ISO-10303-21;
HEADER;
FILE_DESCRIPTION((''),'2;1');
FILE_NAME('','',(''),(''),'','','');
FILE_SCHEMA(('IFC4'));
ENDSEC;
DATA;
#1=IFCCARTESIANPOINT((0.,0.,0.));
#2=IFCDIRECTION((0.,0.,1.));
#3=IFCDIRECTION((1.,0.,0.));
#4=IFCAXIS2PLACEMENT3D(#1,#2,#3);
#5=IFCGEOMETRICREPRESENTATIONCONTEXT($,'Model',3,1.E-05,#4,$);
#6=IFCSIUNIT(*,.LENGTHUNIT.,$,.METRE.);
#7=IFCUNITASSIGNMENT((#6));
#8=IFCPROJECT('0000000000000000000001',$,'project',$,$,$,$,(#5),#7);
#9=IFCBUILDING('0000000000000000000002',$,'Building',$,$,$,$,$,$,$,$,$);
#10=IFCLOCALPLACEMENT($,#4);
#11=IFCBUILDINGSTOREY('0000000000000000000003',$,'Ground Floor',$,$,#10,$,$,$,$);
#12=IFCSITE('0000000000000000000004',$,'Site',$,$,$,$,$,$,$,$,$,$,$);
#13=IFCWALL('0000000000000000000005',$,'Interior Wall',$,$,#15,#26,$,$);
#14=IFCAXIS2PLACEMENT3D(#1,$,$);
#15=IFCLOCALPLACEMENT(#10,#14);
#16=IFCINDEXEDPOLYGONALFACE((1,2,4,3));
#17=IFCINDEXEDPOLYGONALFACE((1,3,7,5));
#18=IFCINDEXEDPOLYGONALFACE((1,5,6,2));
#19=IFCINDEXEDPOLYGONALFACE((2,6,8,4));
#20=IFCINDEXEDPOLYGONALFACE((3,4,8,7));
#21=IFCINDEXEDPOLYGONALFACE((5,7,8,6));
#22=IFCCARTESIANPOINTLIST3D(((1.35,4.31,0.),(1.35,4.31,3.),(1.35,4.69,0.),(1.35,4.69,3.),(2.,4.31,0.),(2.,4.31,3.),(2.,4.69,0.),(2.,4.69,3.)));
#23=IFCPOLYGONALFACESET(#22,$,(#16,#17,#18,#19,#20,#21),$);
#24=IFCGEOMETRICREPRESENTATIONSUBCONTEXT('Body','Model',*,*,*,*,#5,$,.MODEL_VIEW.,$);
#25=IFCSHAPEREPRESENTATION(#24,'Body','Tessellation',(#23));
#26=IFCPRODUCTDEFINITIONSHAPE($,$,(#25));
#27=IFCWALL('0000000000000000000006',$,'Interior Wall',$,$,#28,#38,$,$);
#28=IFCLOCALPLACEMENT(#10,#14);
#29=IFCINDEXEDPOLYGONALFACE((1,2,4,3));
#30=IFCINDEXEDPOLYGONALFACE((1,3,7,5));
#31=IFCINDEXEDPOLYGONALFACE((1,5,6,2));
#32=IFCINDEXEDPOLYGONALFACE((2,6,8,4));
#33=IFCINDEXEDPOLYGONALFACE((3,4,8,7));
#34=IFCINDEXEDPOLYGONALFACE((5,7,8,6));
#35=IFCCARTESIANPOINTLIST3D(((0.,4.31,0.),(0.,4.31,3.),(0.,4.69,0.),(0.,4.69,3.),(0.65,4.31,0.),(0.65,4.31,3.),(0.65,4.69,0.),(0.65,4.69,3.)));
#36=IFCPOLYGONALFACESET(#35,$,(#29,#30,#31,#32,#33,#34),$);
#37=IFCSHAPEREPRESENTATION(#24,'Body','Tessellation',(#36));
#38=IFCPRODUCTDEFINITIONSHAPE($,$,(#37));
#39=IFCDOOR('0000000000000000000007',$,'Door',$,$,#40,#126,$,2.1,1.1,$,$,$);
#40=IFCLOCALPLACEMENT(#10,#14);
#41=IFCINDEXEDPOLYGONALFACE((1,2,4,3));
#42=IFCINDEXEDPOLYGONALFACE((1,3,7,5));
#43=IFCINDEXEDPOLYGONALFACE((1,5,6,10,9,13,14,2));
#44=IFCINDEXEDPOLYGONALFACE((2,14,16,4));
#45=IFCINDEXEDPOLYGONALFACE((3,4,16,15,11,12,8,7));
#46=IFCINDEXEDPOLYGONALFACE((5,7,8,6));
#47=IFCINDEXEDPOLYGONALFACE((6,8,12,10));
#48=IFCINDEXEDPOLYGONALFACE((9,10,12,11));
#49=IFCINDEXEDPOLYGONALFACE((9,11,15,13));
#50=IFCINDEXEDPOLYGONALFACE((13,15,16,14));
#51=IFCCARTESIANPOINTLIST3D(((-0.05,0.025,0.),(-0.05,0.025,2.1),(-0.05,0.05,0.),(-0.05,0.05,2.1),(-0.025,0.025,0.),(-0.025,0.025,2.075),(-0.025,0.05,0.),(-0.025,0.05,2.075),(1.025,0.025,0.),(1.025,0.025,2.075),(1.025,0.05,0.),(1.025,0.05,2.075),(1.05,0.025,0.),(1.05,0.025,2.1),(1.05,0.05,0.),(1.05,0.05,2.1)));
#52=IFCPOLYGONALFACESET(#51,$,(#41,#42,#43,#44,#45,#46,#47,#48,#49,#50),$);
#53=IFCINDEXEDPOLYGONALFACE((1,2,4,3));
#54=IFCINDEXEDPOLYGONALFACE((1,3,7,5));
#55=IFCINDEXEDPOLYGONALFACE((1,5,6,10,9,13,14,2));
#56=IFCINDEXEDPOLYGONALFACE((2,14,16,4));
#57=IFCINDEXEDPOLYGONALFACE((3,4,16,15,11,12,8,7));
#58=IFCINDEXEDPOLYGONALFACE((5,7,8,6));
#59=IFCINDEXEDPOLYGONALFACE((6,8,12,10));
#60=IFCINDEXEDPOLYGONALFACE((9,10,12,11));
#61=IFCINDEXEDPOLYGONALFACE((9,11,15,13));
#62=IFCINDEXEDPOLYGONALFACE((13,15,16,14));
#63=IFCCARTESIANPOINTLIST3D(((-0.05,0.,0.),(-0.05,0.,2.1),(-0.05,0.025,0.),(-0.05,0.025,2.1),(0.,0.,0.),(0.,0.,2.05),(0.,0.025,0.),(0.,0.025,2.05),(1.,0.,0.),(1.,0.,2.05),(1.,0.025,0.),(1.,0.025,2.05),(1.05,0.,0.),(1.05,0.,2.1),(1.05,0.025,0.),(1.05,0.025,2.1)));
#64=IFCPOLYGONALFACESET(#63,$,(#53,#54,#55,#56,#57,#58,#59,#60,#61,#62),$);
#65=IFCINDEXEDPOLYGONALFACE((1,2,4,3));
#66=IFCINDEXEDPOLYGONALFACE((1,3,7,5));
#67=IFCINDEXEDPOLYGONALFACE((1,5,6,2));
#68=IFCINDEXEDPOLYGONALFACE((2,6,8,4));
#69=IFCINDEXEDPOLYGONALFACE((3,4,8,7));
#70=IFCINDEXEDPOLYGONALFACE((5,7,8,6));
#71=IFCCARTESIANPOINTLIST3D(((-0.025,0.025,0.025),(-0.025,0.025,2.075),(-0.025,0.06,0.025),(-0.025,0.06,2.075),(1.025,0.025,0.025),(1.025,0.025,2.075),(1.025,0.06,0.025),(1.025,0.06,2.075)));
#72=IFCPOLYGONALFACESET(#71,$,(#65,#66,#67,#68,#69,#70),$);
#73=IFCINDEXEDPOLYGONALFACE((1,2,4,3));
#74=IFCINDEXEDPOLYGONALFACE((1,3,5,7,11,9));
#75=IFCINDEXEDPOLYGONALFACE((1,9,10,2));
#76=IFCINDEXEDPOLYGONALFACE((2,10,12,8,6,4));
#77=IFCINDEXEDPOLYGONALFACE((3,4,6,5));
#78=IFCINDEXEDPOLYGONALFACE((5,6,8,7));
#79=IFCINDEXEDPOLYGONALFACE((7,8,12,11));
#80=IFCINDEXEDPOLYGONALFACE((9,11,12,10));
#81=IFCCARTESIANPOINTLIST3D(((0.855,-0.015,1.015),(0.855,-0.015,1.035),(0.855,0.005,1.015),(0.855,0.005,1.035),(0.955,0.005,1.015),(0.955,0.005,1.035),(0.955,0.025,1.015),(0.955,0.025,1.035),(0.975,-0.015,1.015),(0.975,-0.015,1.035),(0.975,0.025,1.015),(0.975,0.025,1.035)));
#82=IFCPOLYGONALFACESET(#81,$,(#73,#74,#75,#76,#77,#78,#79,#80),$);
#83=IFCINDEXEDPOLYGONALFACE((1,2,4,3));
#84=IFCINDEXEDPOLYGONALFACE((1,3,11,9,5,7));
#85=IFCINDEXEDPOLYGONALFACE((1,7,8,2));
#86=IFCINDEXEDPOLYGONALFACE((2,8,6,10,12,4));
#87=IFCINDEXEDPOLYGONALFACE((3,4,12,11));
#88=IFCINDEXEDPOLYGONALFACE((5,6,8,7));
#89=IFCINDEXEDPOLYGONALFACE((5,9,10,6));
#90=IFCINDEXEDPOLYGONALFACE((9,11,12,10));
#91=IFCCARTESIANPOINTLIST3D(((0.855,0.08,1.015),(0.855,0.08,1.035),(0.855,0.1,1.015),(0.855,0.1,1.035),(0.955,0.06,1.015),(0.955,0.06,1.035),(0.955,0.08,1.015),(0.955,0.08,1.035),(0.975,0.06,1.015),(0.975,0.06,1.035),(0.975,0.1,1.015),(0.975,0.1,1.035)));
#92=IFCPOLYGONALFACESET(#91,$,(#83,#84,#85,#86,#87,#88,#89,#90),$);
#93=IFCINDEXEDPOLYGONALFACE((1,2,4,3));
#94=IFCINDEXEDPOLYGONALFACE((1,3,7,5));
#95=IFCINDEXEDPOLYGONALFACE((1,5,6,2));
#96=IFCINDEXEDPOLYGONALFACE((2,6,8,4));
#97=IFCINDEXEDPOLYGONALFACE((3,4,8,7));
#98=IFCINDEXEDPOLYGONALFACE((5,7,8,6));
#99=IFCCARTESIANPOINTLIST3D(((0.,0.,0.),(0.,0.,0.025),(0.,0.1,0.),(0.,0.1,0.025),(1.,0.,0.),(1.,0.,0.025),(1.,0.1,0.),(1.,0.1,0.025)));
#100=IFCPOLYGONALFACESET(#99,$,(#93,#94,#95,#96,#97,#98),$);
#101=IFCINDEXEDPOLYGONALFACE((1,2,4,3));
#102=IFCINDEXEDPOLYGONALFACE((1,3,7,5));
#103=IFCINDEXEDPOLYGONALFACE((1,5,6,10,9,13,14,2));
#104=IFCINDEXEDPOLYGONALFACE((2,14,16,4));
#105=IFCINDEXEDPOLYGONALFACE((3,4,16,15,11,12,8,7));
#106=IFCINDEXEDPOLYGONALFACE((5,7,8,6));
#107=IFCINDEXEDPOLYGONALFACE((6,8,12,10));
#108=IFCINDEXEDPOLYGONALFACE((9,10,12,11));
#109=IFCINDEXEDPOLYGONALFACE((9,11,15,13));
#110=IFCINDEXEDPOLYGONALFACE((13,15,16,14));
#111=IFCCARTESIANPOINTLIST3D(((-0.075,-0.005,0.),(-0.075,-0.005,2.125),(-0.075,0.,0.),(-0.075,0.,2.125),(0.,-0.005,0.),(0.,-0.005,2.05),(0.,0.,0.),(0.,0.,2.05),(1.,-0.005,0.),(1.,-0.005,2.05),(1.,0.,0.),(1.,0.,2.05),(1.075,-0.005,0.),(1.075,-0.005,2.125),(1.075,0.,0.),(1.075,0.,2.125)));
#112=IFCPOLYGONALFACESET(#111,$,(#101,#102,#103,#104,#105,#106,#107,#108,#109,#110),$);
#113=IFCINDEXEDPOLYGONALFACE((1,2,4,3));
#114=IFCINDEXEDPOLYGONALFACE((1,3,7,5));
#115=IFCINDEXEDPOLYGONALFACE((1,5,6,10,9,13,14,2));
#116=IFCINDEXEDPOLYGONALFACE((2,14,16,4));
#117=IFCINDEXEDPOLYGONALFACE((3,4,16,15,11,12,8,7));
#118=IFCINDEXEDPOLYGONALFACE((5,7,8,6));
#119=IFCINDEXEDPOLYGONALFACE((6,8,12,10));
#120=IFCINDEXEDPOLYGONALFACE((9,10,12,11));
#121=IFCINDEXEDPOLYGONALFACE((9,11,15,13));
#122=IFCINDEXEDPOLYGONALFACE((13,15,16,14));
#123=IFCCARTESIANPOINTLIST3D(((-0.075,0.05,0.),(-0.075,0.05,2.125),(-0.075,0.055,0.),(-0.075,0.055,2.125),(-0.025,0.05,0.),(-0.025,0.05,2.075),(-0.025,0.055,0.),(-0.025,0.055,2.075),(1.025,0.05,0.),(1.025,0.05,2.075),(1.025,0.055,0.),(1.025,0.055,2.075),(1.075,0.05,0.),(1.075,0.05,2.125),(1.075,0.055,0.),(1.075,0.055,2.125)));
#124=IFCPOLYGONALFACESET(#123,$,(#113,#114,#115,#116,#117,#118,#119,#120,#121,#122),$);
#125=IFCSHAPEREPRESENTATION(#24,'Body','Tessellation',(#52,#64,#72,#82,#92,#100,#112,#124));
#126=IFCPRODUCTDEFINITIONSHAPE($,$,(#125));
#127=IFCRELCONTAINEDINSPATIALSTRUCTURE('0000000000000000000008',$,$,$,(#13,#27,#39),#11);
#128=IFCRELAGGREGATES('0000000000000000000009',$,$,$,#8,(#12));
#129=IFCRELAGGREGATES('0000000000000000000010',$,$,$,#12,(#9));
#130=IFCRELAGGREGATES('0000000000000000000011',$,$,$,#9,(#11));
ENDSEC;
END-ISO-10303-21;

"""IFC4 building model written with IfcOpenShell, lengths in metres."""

from ifc_helpers import new_model, si_unit, frame, origin_with_axes, place, context, subcontext, project, spatial, line, indexed_curve, outline, extrude, element, save


model = new_model("IFC4")

# Units and contexts
model_context = context("Model", 3, precision=1e-05, world=origin_with_axes())
body_context = subcontext(model_context, "Body", "Model", "MODEL_VIEW")
ifc_project = project(units=[si_unit("LENGTHUNIT", "METRE")], contexts=[model_context])

# Site, building, storey
site = spatial("IfcSite", under=ifc_project, Name="Site")
building = spatial("IfcBuilding", under=site, Name="Building")
storey_placement = place(None, origin_with_axes())
storey = spatial("IfcBuildingStorey", under=building, at=storey_placement, Name="Ground Floor")

# Walls
for number, where, z_axis, x_axis, name in (
    (1, (2.0, 4.5, 0.0), (0.0, 0.0, 1.0), (-1.0, 0.0, 0.0), "Interior Wall"),
    (2, (0.65, 4.5, 0.0), (0.0, 0.0, 1.0), (-1.0, 0.0, 0.0), "Interior Wall"),
):
    element("IfcWall", number, at=place(storey_placement, frame(where, z_axis=z_axis, x_axis=x_axis)), inside=storey, Name=name, context=body_context, shape_type="SweptSolid", body=[
        extrude(outline(indexed_curve([(0.0, 0.0), (0.0, 0.38), (0.65, 0.38), (0.65, 0.0), (0.0, 0.0)], self_intersect=False)), frame((0.0, -0.19, 0.0), z_axis=(0.0, 0.0, 1.0), x_axis=(1.0, 0.0, 0.0)), (0.0, 0.0, 1.0), 3.0),
    ])

# Door
door_1_placement = place(storey_placement, frame((-0.05, 0.0, 0.0), z_axis=(0.0, 0.0, 1.0), x_axis=(1.0, 0.0, 0.0)))
element("IfcDoor", 3, at=door_1_placement, inside=storey, Name="Door", OverallHeight=2.1, OverallWidth=1.1, context=body_context, shape_type="SweptSolid", body=[
    extrude(outline(indexed_curve([(0.0, 0.0), (0.0, 2.1), (1.1, 2.1), (1.1, 0.0), (1.075, 0.0), (1.075, 2.075), (0.025, 2.075), (0.025, 0.0)], segments=[line(1, 2, 3, 4, 5, 6, 7, 8, 1)])), frame((0.0, 0.025, 0.0), z_axis=(0.0, -1.0, 0.0), x_axis=(1.0, 0.0, 0.0)), (0.0, 0.0, -1.0), 0.025),
    extrude(outline(indexed_curve([(0.0, 0.0), (0.0, 2.1), (1.1, 2.1), (1.1, 0.0), (1.05, 0.0), (1.05, 2.05), (0.05, 2.05), (0.05, 0.0)], segments=[line(1, 2, 3, 4, 5, 6, 7, 8, 1)])), frame((0.0, 0.0, 0.0), z_axis=(0.0, -1.0, 0.0), x_axis=(1.0, 0.0, 0.0)), (0.0, 0.0, -1.0), 0.025),
    extrude(outline(indexed_curve([(0.0, 0.0), (1.05, 0.0), (1.05, 0.035), (0.0, 0.035)], segments=[line(1, 2, 3, 4, 1)])), frame((0.025, 0.025, 0.025), z_axis=(0.0, 0.0, 1.0), x_axis=(1.0, 0.0, 0.0)), (0.0, 0.0, 1.0), 2.05),
    extrude(outline(indexed_curve([(0.0, 0.0), (0.0, -0.04), (-0.12, -0.04), (-0.12, -0.02), (-0.02, -0.02), (-0.02, 0.0)], segments=[line(1, 2, 3, 4, 5, 6, 1)])), frame((1.025, 0.025, 1.015), z_axis=(0.0, 0.0, 1.0), x_axis=(1.0, 0.0, 0.0)), (0.0, 0.0, 1.0), 0.02),
    extrude(outline(indexed_curve([(0.0, 0.0), (0.0, 0.04), (-0.12, 0.04), (-0.12, 0.02), (-0.02, 0.02), (-0.02, 0.0)], segments=[line(1, 2, 3, 4, 5, 6, 1)])), frame((1.025, 0.06, 1.015), z_axis=(0.0, 0.0, 1.0), x_axis=(1.0, 0.0, 0.0)), (0.0, 0.0, 1.0), 0.02),
    extrude(outline(indexed_curve([(0.0, 0.0), (1.0, 0.0), (1.0, 0.1), (0.0, 0.1)], segments=[line(1, 2, 3, 4, 1)])), frame((0.05, 0.0, 0.0), z_axis=(0.0, 0.0, 1.0), x_axis=(1.0, 0.0, 0.0)), (0.0, 0.0, 1.0), 0.025),
    extrude(outline(indexed_curve([(0.0, 0.0), (0.0, 2.125), (1.15, 2.125), (1.15, 0.0), (1.075, 0.0), (1.075, 2.05), (0.075, 2.05), (0.075, 0.0)], segments=[line(1, 2, 3, 4, 5, 6, 7, 8, 1)])), frame((-0.025, -0.005, 0.0), z_axis=(0.0, -1.0, 0.0), x_axis=(1.0, 0.0, 0.0)), (0.0, 0.0, -1.0), 0.005),
    extrude(outline(indexed_curve([(0.0, 0.0), (0.0, 2.125), (1.15, 2.125), (1.15, 0.0), (1.1, 0.0), (1.1, 2.075), (0.05, 2.075), (0.05, 0.0)], segments=[line(1, 2, 3, 4, 5, 6, 7, 8, 1)])), frame((-0.025, 0.05, 0.0), z_axis=(0.0, -1.0, 0.0), x_axis=(1.0, 0.0, 0.0)), (0.0, 0.0, -1.0), 0.005),
])

save(model, "model.ifc")
